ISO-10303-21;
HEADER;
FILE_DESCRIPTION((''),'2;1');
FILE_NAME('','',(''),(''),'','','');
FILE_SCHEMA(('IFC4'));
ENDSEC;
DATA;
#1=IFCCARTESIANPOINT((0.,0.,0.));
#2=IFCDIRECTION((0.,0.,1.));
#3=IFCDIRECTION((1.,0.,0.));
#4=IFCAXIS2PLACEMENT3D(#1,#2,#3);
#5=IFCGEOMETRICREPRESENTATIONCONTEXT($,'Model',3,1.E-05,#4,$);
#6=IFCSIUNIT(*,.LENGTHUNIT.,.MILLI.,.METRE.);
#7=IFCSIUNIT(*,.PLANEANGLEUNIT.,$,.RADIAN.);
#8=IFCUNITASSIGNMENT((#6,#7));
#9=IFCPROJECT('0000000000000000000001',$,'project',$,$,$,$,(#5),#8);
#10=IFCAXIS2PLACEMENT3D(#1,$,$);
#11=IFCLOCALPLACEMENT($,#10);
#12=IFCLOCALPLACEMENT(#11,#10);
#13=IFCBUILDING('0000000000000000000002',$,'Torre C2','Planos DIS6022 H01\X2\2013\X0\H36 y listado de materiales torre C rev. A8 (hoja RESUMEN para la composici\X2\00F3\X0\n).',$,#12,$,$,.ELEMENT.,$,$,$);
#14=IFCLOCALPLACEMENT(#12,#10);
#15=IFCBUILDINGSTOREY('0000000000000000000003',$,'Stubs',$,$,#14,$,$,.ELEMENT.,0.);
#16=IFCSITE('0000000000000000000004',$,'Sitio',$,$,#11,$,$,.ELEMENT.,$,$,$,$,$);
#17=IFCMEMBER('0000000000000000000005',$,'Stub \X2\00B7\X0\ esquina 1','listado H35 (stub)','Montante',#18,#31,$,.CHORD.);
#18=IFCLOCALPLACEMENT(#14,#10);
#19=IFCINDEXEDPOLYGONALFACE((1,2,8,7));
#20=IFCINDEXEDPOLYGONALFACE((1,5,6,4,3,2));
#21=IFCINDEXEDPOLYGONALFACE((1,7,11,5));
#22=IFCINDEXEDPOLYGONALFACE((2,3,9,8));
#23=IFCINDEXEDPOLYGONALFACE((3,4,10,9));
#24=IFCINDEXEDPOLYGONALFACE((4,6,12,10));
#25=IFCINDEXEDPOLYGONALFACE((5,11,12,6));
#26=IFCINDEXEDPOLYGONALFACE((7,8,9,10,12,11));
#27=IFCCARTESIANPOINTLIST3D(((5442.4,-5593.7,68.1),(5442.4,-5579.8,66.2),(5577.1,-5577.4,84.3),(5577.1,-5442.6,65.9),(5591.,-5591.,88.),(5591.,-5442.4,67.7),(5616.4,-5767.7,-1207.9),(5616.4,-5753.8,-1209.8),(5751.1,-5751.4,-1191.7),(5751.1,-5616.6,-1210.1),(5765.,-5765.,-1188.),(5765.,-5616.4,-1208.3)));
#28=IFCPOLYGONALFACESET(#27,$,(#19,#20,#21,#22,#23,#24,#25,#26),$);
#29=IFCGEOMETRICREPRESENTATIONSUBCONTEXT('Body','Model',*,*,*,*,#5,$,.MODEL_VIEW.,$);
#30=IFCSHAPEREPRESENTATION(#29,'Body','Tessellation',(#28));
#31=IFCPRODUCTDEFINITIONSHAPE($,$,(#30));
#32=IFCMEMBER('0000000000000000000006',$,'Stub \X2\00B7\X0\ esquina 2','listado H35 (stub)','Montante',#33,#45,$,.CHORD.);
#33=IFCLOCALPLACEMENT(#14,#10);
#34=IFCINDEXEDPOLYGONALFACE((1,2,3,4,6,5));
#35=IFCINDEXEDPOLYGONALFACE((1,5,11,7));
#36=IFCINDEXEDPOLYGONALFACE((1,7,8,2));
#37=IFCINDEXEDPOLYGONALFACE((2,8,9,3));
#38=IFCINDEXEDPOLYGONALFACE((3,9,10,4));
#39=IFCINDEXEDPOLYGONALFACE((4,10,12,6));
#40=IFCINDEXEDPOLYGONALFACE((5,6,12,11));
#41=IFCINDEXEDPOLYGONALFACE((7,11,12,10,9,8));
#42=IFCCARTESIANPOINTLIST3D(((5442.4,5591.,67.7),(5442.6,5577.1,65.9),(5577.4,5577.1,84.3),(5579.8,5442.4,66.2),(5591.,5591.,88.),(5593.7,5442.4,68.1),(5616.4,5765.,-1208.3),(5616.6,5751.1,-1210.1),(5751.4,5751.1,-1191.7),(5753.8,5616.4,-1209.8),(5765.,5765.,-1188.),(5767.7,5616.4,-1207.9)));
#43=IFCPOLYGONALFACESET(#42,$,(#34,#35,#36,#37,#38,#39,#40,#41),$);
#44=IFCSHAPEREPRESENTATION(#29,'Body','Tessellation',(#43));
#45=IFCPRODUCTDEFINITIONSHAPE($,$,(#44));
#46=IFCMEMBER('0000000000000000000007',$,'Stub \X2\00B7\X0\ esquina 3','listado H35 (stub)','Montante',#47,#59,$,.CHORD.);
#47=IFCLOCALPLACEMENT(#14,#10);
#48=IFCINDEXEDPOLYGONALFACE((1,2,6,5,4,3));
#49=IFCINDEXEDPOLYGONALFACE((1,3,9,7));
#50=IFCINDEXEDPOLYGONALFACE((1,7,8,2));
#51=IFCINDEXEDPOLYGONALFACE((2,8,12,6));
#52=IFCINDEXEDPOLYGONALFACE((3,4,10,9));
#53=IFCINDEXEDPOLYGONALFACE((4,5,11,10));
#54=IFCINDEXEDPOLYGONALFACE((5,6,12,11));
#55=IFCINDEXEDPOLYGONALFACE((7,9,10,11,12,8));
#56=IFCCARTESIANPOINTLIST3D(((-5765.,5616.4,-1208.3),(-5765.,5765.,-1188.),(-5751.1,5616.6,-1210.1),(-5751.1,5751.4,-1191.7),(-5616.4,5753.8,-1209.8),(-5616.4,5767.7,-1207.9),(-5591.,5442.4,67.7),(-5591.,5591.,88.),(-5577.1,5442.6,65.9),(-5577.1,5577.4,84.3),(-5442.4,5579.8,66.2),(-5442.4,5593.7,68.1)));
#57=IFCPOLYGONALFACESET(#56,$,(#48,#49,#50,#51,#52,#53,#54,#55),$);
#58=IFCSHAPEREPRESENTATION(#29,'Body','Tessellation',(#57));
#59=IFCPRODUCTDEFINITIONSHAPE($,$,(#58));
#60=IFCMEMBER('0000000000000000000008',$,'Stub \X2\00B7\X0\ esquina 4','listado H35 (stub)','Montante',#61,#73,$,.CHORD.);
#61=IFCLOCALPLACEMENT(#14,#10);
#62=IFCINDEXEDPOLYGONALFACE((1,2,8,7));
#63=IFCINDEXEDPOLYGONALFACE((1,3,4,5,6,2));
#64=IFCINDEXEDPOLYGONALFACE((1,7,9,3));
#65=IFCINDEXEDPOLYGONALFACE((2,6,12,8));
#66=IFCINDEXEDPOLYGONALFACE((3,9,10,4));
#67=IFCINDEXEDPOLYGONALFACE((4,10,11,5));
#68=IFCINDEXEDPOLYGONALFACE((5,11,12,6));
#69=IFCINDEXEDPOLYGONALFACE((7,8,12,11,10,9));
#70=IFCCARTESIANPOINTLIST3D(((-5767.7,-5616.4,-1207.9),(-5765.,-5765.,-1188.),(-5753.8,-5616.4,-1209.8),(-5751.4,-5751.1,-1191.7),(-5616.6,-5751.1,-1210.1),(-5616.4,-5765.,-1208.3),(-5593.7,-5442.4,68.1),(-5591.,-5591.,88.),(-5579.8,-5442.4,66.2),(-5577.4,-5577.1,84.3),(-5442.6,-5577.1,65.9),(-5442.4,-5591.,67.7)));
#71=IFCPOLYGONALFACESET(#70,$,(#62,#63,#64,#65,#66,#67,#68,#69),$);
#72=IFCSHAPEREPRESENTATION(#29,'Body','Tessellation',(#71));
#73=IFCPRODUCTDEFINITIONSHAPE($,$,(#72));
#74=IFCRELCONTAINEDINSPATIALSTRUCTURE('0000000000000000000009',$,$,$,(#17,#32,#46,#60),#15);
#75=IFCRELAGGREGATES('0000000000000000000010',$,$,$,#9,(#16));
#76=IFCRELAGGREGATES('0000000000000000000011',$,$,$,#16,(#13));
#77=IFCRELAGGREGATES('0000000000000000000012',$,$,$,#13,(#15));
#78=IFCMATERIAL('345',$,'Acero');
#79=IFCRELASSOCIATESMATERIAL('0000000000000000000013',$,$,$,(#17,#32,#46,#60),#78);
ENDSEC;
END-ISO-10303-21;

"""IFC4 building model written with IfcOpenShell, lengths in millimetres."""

from ifc_helpers import new_model, si_unit, frame, frame_2d, origin, origin_with_axes, place, context, subcontext, project, spatial, l_section, extrude, material, element, save


model = new_model("IFC4")

# Units and contexts
model_context = context("Model", 3, precision=1e-05, world=origin_with_axes())
body_context = subcontext(model_context, "Body", "Model", "MODEL_VIEW")
ifc_project = project(units=[si_unit("LENGTHUNIT", "METRE", prefix="MILLI"), si_unit("PLANEANGLEUNIT", "RADIAN")], contexts=[model_context])

# Site, building, storey
site_placement = place(None, origin())
site = spatial("IfcSite", under=ifc_project, at=site_placement, Name="Sitio", CompositionType="ELEMENT")
building_placement = place(site_placement, origin())
building = spatial("IfcBuilding", under=site, at=building_placement, Name="Torre C2", Description="Planos DIS6022 H01–H36 y listado de materiales torre C rev. A8 (hoja RESUMEN para la composición).", CompositionType="ELEMENT")
storey_placement = place(building_placement, origin())
storey = spatial("IfcBuildingStorey", under=building, at=storey_placement, Name="Stubs", CompositionType="ELEMENT", Elevation=0.0)

# Members
ifc_material = material(Name="345", Category="Acero")
for number, where, z_axis, x_axis, name in (
    (1, (5591.0, -5591.0, 88.0), (0.133897, -0.133897, -0.981908), (-0.990995, -0.018091, -0.132669), "Stub · esquina 1"),
    (2, (5591.0, 5591.0, 88.0), (0.133897, 0.133897, -0.981908), (0.018091, -0.990995, -0.132669), "Stub · esquina 2"),
    (3, (-5591.0, 5591.0, 88.0), (-0.133897, 0.133897, -0.981908), (0.990995, 0.018091, -0.132669), "Stub · esquina 3"),
    (4, (-5591.0, -5591.0, 88.0), (-0.133897, -0.133897, -0.981908), (-0.018091, 0.990995, -0.132669), "Stub · esquina 4"),
):
    element("IfcMember", number, at=place(storey_placement, frame(where, z_axis=z_axis, x_axis=x_axis)), inside=storey, material=ifc_material, Name=name, Description="listado H35 (stub)", ObjectType="Montante", PredefinedType="CHORD", context=body_context, shape_type="SweptSolid", body=[
        extrude(l_section(Depth=150.0, Width=150.0, Thickness=14.0, at=frame_2d((75.0, 75.0))), None, (0.0, 0.0, 1.0), 1299.5),
    ])

save(model, "model.ifc")
